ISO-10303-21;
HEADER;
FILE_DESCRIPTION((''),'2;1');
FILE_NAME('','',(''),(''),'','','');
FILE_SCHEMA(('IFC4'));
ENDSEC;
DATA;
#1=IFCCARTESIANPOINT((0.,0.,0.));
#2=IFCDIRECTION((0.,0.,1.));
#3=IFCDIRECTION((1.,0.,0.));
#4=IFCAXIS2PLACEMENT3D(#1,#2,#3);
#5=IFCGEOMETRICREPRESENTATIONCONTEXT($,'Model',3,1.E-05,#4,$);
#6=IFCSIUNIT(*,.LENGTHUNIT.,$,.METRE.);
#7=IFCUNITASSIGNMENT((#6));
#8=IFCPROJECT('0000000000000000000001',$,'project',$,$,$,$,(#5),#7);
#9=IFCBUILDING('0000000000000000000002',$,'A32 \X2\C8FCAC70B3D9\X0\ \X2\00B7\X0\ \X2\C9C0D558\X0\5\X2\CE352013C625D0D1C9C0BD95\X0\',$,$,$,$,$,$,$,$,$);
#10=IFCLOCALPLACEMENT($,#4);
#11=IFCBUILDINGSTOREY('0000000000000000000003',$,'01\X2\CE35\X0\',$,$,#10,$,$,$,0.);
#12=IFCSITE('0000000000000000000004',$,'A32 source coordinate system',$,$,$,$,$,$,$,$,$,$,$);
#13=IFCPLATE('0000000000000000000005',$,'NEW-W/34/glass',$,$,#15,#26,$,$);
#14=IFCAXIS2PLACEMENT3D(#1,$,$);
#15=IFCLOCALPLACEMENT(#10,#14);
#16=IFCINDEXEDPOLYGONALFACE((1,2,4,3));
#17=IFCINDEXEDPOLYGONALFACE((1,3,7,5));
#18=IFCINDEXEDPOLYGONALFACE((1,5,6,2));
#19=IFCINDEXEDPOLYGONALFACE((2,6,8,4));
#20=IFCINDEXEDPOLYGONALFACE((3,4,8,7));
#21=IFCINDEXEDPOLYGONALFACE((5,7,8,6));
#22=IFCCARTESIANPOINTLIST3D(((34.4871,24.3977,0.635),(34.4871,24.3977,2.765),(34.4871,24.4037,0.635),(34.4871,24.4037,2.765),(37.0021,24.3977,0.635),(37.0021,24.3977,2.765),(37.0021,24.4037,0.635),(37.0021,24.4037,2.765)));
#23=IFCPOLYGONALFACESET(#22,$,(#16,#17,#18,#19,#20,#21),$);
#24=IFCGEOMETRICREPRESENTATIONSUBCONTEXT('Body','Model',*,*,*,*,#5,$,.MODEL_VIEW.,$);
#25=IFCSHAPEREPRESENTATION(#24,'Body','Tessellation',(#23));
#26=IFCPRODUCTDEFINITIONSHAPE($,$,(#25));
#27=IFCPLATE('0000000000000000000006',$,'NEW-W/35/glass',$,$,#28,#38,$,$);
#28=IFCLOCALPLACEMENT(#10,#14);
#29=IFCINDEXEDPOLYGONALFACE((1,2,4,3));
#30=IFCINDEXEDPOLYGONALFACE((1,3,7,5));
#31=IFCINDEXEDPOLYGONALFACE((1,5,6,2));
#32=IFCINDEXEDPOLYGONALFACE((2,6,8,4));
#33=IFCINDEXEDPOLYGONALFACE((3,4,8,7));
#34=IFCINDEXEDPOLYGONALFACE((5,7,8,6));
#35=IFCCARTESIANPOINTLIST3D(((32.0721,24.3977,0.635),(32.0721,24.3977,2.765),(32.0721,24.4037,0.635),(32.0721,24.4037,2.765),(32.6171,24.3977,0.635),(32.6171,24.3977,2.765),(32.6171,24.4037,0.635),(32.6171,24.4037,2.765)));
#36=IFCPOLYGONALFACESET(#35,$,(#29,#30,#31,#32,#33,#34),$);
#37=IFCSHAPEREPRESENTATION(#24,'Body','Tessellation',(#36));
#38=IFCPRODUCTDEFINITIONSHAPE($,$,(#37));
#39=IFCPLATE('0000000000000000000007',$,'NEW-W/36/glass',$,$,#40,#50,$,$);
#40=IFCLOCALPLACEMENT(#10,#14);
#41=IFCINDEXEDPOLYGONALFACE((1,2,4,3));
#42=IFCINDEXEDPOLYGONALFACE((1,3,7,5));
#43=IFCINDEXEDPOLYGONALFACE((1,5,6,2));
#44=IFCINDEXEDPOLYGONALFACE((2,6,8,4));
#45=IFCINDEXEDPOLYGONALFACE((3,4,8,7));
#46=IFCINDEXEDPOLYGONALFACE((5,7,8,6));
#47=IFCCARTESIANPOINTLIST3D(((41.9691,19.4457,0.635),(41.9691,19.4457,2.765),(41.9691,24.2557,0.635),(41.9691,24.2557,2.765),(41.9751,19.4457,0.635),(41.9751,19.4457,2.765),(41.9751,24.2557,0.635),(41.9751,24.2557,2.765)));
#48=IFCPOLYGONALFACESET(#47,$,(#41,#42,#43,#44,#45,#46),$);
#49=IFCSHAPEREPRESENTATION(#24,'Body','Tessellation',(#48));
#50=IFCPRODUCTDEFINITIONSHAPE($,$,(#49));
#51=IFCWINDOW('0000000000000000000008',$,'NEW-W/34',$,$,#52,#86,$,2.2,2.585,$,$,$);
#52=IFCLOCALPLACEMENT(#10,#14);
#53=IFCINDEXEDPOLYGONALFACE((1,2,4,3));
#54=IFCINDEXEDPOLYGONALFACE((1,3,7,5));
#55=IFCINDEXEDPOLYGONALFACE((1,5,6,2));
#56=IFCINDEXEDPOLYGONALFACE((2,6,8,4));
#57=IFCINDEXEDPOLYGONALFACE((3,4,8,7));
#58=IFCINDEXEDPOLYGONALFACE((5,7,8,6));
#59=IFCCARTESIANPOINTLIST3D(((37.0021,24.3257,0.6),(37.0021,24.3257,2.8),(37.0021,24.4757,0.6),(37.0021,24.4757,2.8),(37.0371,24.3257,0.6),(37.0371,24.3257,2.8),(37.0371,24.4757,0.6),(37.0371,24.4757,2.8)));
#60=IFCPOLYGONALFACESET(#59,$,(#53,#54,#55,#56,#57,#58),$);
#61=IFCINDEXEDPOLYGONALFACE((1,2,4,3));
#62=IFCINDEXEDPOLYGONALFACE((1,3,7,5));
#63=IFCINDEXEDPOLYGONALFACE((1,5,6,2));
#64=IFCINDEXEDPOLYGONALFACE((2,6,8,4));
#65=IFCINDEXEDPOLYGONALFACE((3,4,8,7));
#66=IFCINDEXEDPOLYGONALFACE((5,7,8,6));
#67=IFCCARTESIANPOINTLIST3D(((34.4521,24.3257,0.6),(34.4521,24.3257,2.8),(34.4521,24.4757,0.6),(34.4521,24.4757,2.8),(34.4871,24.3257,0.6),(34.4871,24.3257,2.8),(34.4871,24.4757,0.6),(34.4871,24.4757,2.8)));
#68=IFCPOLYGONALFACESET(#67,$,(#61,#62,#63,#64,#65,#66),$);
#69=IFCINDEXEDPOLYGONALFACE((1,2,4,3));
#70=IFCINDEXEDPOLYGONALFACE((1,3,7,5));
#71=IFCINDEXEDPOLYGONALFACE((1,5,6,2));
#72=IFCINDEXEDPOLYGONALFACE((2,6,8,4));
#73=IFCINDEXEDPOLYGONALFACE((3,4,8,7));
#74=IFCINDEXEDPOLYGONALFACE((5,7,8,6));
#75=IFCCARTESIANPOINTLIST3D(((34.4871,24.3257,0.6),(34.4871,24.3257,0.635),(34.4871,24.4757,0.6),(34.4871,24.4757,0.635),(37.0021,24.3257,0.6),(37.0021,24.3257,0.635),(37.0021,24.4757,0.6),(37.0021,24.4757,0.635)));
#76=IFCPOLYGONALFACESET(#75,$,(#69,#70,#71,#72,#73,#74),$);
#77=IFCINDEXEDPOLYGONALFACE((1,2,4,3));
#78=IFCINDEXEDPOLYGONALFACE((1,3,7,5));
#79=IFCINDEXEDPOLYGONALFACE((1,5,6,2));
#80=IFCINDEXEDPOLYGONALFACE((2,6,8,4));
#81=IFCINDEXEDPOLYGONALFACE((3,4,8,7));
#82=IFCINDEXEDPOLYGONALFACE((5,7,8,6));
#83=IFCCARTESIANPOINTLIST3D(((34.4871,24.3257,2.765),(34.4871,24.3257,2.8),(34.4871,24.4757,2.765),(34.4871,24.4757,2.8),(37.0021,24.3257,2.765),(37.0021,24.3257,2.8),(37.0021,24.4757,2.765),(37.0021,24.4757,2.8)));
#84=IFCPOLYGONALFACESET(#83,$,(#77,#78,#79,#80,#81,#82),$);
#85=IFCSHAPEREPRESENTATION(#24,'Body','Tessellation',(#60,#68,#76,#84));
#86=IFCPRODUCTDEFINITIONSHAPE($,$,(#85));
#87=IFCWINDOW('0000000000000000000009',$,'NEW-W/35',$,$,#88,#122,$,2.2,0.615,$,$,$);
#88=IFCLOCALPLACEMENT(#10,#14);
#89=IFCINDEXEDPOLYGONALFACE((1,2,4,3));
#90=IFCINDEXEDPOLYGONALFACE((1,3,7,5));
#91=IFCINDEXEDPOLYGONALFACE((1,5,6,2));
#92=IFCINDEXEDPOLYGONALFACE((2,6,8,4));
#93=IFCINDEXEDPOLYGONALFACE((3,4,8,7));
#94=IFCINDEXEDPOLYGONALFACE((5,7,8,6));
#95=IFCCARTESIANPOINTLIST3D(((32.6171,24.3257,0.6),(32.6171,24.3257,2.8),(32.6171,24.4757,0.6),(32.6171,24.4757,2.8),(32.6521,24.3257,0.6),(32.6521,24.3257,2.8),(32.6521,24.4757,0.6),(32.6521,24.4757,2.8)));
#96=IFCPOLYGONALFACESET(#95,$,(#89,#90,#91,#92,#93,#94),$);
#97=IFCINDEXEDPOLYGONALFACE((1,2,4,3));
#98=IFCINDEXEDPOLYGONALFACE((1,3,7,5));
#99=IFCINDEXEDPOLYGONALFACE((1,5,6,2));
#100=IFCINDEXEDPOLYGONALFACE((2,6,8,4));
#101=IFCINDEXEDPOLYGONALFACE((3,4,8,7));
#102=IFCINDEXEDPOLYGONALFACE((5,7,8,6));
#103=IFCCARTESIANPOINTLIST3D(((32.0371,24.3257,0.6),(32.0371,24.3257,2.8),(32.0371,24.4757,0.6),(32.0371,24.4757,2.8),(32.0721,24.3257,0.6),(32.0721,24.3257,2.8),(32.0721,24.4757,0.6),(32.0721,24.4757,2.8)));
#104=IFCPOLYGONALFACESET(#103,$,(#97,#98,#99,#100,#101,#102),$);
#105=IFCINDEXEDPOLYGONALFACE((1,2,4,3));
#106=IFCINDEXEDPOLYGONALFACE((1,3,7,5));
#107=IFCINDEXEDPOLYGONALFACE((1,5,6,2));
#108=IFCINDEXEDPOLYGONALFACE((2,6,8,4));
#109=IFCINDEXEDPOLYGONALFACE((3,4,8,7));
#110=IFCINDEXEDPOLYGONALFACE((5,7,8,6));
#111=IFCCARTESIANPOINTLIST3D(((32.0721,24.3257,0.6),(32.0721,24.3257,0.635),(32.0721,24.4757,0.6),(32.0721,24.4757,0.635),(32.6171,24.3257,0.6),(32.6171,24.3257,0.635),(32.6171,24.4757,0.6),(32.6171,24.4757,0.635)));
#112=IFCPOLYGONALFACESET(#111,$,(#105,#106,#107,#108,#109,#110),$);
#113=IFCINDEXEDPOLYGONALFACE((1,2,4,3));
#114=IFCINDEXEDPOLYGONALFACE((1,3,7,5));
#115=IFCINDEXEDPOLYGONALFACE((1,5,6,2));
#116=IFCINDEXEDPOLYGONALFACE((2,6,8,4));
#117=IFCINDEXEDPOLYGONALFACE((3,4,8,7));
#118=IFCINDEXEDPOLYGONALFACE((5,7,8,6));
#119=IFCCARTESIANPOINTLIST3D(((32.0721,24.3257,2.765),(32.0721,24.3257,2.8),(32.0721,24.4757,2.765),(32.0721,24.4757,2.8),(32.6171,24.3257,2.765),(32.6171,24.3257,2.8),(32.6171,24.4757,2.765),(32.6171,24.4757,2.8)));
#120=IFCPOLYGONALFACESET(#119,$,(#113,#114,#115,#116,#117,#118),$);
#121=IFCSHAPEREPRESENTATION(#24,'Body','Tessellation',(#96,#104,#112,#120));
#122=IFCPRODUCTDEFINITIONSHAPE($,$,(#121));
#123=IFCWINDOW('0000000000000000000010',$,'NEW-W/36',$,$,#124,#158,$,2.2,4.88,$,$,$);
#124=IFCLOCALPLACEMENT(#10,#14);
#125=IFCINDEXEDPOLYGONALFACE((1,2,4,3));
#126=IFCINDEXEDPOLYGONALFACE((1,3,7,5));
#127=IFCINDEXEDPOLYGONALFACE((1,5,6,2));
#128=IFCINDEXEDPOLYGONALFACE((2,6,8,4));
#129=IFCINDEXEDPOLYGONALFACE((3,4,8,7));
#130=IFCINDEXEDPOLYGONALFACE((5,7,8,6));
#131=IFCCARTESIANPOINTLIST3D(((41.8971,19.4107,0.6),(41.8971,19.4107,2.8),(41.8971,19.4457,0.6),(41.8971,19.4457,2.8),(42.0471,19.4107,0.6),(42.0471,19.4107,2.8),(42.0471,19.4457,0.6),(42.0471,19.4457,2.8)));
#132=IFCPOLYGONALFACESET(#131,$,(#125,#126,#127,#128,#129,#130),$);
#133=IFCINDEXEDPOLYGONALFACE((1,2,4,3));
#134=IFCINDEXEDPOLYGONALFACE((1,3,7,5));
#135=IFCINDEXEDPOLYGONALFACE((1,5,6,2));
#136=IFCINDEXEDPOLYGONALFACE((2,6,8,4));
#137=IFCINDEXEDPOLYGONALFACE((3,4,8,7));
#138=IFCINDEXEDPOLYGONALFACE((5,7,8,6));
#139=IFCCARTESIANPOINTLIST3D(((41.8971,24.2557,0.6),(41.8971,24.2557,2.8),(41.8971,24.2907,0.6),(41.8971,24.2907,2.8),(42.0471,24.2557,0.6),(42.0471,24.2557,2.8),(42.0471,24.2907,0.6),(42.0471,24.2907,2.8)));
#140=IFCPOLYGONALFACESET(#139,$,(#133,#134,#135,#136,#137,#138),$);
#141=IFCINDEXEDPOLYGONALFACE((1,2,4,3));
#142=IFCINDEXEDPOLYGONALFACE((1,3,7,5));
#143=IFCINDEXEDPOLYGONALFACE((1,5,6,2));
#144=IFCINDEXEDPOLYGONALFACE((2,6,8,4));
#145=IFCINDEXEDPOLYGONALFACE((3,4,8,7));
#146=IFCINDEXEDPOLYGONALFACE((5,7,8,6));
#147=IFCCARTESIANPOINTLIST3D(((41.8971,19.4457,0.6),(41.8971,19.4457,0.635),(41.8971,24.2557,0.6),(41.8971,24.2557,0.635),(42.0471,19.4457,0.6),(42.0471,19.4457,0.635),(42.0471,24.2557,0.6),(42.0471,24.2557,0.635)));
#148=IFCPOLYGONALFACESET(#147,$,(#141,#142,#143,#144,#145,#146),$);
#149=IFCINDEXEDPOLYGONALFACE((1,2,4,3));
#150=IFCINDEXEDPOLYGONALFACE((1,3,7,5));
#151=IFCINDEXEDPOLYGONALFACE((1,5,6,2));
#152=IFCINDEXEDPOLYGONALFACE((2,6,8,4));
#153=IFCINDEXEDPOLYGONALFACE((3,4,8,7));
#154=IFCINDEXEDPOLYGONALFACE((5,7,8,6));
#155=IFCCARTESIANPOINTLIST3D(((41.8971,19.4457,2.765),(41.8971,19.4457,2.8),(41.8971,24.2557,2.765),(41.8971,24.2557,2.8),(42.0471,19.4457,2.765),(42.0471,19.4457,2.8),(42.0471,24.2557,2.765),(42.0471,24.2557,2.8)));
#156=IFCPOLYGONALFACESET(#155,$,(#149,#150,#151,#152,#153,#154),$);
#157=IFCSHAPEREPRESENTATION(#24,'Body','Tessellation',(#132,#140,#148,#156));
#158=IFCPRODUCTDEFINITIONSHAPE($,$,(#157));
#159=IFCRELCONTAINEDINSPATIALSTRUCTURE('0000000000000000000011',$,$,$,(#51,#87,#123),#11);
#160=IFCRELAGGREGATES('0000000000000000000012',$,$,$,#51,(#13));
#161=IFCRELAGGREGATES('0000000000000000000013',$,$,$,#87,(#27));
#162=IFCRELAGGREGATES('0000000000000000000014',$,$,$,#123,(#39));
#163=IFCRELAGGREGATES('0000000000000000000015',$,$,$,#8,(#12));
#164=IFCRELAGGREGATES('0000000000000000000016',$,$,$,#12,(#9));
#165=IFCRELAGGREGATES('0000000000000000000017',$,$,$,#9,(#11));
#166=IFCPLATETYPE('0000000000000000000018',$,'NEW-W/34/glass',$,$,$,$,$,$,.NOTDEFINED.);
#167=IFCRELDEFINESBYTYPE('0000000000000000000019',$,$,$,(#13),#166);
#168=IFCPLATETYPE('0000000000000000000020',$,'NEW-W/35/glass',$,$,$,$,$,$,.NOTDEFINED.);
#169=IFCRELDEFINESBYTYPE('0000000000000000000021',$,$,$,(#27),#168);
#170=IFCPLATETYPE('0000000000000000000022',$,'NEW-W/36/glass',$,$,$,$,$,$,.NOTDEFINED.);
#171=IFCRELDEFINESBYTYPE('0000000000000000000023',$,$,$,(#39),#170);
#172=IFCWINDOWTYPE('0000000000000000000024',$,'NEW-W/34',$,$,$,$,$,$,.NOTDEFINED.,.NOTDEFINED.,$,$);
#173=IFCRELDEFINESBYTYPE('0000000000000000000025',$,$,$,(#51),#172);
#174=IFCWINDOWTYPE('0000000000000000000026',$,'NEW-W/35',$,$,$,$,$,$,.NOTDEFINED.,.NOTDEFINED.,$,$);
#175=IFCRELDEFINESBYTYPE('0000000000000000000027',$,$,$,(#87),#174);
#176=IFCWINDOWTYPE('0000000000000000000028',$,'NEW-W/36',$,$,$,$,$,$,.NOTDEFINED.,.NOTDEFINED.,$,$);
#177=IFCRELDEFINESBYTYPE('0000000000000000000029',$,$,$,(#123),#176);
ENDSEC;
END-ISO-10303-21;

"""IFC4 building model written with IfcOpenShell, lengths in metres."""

from ifc_helpers import new_model, si_unit, frame, origin, origin_with_axes, place, context, subcontext, project, spatial, polyline, outline, extrude, source, transform, mapped, type_object, type_shapes, element, aggregate, save


model = new_model("IFC4")

# Units and contexts
model_context = context("Model", 3, precision=1e-05, world=origin_with_axes())
body_context = subcontext(model_context, "Body", "Model", "MODEL_VIEW")
ifc_project = project(units=[si_unit("LENGTHUNIT", "METRE")], contexts=[model_context])

# Plates
plate_type_1 = type_object("IfcPlateType", Name="NEW-W/34/glass", PredefinedType="NOTDEFINED")
shared_shape_1 = source(origin(), body_context, "Body", "SweptSolid", [
    extrude(outline(polyline([(37.0021, 24.3977), (34.4871, 24.3977), (34.4871, 24.4037), (37.0021, 24.4037), (37.0021, 24.3977)])), frame((0.0, 0.0, 0.635)), (0.0, 0.0, 1.0), 2.13),
])
type_shapes(plate_type_1, [shared_shape_1])
storey_placement = place(None, origin_with_axes())
window_1_placement = place(storey_placement, origin_with_axes())
plate_1_placement = place(window_1_placement, origin_with_axes())
plate_1 = element("IfcPlate", 1, at=plate_1_placement, type_object=plate_type_1, Name="NEW-W/34/glass", context=body_context, shape_type="MappedRepresentation", body=[
    mapped(shared_shape_1, transform((0.0, 0.0, 0.0), scale=1.0)),
])
plate_type_2 = type_object("IfcPlateType", Name="NEW-W/35/glass", PredefinedType="NOTDEFINED")
shared_shape_2 = source(origin(), body_context, "Body", "SweptSolid", [
    extrude(outline(polyline([(32.6171, 24.3977), (32.0721, 24.3977), (32.0721, 24.4037), (32.6171, 24.4037), (32.6171, 24.3977)])), frame((0.0, 0.0, 0.635)), (0.0, 0.0, 1.0), 2.13),
])
type_shapes(plate_type_2, [shared_shape_2])
window_2_placement = place(storey_placement, origin_with_axes())
plate_2_placement = place(window_2_placement, origin_with_axes())
plate_2 = element("IfcPlate", 2, at=plate_2_placement, type_object=plate_type_2, Name="NEW-W/35/glass", context=body_context, shape_type="MappedRepresentation", body=[
    mapped(shared_shape_2, transform((0.0, 0.0, 0.0), scale=1.0)),
])
plate_type_3 = type_object("IfcPlateType", Name="NEW-W/36/glass", PredefinedType="NOTDEFINED")
shared_shape_3 = source(origin(), body_context, "Body", "SweptSolid", [
    extrude(outline(polyline([(41.9751, 19.4457), (41.9691, 19.4457), (41.9691, 24.2557), (41.9751, 24.2557), (41.9751, 19.4457)])), frame((0.0, 0.0, 0.635)), (0.0, 0.0, 1.0), 2.13),
])
type_shapes(plate_type_3, [shared_shape_3])
window_3_placement = place(storey_placement, origin_with_axes())
plate_3_placement = place(window_3_placement, origin_with_axes())
plate_3 = element("IfcPlate", 3, at=plate_3_placement, type_object=plate_type_3, Name="NEW-W/36/glass", context=body_context, shape_type="MappedRepresentation", body=[
    mapped(shared_shape_3, transform((0.0, 0.0, 0.0), scale=1.0)),
])

# Site, building, storey
site = spatial("IfcSite", under=ifc_project, Name="A32 source coordinate system")
building = spatial("IfcBuilding", under=site, Name="A32 주거동 · 지하5층–옥탑지붕")
storey = spatial("IfcBuildingStorey", under=building, at=storey_placement, Name="01층", Elevation=0.0)

# Windows
window_type_1 = type_object("IfcWindowType", Name="NEW-W/34", PartitioningType="NOTDEFINED", PredefinedType="NOTDEFINED")
shared_shape_4 = source(origin(), body_context, "Body", "SweptSolid", [
    extrude(outline(polyline([(37.0021, 24.3257), (37.0021, 24.4757), (37.0371, 24.4757), (37.0371, 24.3257), (37.0021, 24.3257)])), frame((0.0, 0.0, 0.6)), (0.0, 0.0, 1.0), 2.2),
    extrude(outline(polyline([(34.4521, 24.3257), (34.4521, 24.4757), (34.4871, 24.4757), (34.4871, 24.3257), (34.4521, 24.3257)])), frame((0.0, 0.0, 0.6)), (0.0, 0.0, 1.0), 2.2),
    extrude(outline(polyline([(37.0021, 24.3257), (37.0021, 24.4757), (34.4871, 24.4757), (34.4871, 24.3257), (37.0021, 24.3257)])), frame((0.0, 0.0, 0.6)), (0.0, 0.0, 1.0), 0.035),
    extrude(outline(polyline([(37.0021, 24.3257), (37.0021, 24.4757), (34.4871, 24.4757), (34.4871, 24.3257), (37.0021, 24.3257)])), frame((0.0, 0.0, 2.765)), (0.0, 0.0, 1.0), 0.035),
])
type_shapes(window_type_1, [shared_shape_4])
window_1 = element("IfcWindow", 4, at=window_1_placement, inside=storey, type_object=window_type_1, Name="NEW-W/34", OverallHeight=2.2, OverallWidth=2.585, context=body_context, shape_type="MappedRepresentation", body=[
    mapped(shared_shape_4, transform((0.0, 0.0, 0.0), scale=1.0)),
])
aggregate(window_1, [plate_1])
window_type_2 = type_object("IfcWindowType", Name="NEW-W/35", PartitioningType="NOTDEFINED", PredefinedType="NOTDEFINED")
shared_shape_5 = source(origin(), body_context, "Body", "SweptSolid", [
    extrude(outline(polyline([(32.6171, 24.3257), (32.6171, 24.4757), (32.6521, 24.4757), (32.6521, 24.3257), (32.6171, 24.3257)])), frame((0.0, 0.0, 0.6)), (0.0, 0.0, 1.0), 2.2),
    extrude(outline(polyline([(32.0371, 24.3257), (32.0371, 24.4757), (32.0721, 24.4757), (32.0721, 24.3257), (32.0371, 24.3257)])), frame((0.0, 0.0, 0.6)), (0.0, 0.0, 1.0), 2.2),
    extrude(outline(polyline([(32.6171, 24.3257), (32.6171, 24.4757), (32.0721, 24.4757), (32.0721, 24.3257), (32.6171, 24.3257)])), frame((0.0, 0.0, 0.6)), (0.0, 0.0, 1.0), 0.035),
    extrude(outline(polyline([(32.6171, 24.3257), (32.6171, 24.4757), (32.0721, 24.4757), (32.0721, 24.3257), (32.6171, 24.3257)])), frame((0.0, 0.0, 2.765)), (0.0, 0.0, 1.0), 0.035),
])
type_shapes(window_type_2, [shared_shape_5])
window_2 = element("IfcWindow", 5, at=window_2_placement, inside=storey, type_object=window_type_2, Name="NEW-W/35", OverallHeight=2.2, OverallWidth=0.615, context=body_context, shape_type="MappedRepresentation", body=[
    mapped(shared_shape_5, transform((0.0, 0.0, 0.0), scale=1.0)),
])
aggregate(window_2, [plate_2])
window_type_3 = type_object("IfcWindowType", Name="NEW-W/36", PartitioningType="NOTDEFINED", PredefinedType="NOTDEFINED")
shared_shape_6 = source(origin(), body_context, "Body", "SweptSolid", [
    extrude(outline(polyline([(41.8971, 19.4107), (41.8971, 19.4457), (42.0471, 19.4457), (42.0471, 19.4107), (41.8971, 19.4107)])), frame((0.0, 0.0, 0.6)), (0.0, 0.0, 1.0), 2.2),
    extrude(outline(polyline([(41.8971, 24.2557), (41.8971, 24.2907), (42.0471, 24.2907), (42.0471, 24.2557), (41.8971, 24.2557)])), frame((0.0, 0.0, 0.6)), (0.0, 0.0, 1.0), 2.2),
    extrude(outline(polyline([(42.0471, 19.4457), (42.0471, 24.2557), (41.8971, 24.2557), (41.8971, 19.4457), (42.0471, 19.4457)])), frame((0.0, 0.0, 0.6)), (0.0, 0.0, 1.0), 0.035),
    extrude(outline(polyline([(42.0471, 19.4457), (42.0471, 24.2557), (41.8971, 24.2557), (41.8971, 19.4457), (42.0471, 19.4457)])), frame((0.0, 0.0, 2.765)), (0.0, 0.0, 1.0), 0.035),
])
type_shapes(window_type_3, [shared_shape_6])
window_3 = element("IfcWindow", 6, at=window_3_placement, inside=storey, type_object=window_type_3, Name="NEW-W/36", OverallHeight=2.2, OverallWidth=4.88, context=body_context, shape_type="MappedRepresentation", body=[
    mapped(shared_shape_6, transform((0.0, 0.0, 0.0), scale=1.0)),
])
aggregate(window_3, [plate_3])

save(model, "model.ifc")
